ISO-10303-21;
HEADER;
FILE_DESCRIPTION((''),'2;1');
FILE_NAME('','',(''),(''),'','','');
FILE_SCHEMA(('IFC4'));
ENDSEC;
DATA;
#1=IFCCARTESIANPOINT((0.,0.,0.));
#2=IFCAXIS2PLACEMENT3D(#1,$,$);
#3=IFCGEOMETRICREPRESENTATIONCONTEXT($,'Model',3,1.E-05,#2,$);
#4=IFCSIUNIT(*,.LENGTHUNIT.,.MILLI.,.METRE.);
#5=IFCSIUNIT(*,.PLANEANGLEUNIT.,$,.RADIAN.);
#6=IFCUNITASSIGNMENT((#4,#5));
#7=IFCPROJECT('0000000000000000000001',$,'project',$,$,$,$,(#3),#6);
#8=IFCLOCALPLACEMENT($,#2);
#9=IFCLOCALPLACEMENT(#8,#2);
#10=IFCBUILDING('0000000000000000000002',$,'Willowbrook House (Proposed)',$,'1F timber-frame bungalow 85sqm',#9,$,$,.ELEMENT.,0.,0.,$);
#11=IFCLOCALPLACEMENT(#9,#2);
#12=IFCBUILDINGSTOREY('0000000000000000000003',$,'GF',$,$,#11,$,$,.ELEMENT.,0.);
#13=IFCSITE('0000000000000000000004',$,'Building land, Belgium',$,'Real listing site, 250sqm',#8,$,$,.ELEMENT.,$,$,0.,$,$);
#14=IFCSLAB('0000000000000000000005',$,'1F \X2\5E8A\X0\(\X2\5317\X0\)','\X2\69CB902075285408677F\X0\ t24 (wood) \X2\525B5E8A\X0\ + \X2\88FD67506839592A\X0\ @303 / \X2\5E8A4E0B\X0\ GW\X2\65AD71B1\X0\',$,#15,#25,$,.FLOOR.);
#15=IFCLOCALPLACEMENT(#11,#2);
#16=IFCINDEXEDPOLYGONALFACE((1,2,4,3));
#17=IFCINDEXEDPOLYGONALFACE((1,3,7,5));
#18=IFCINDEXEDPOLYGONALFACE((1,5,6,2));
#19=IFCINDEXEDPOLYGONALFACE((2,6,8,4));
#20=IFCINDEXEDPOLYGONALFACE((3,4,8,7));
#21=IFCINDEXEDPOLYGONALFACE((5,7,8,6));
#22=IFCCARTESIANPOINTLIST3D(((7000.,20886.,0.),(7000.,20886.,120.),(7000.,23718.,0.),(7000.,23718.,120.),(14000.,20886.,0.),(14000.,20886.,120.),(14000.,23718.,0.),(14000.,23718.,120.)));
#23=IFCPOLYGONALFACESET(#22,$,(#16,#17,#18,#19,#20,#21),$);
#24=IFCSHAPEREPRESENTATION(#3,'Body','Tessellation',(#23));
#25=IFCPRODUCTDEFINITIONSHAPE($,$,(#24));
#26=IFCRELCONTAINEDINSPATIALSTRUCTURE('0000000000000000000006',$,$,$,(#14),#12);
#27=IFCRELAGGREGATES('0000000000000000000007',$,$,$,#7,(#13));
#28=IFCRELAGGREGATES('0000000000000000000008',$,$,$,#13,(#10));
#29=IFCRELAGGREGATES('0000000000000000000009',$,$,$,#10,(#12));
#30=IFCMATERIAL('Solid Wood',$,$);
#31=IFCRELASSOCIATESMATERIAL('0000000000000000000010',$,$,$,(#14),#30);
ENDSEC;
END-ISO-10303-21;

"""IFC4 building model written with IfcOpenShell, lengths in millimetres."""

from ifc_helpers import new_model, si_unit, frame, frame_2d, origin, place, context, project, spatial, rectangle, extrude, material, element, save


model = new_model("IFC4")

# Units and contexts
model_context = context("Model", 3, precision=1e-05, world=origin())
ifc_project = project(units=[si_unit("LENGTHUNIT", "METRE", prefix="MILLI"), si_unit("PLANEANGLEUNIT", "RADIAN")], contexts=[model_context])

# Site, building, storey
site_placement = place(None, origin())
site = spatial("IfcSite", under=ifc_project, at=site_placement, Name="Building land, Belgium", ObjectType="Real listing site, 250sqm", CompositionType="ELEMENT", RefElevation=0.0)
building_placement = place(site_placement, origin())
building = spatial("IfcBuilding", under=site, at=building_placement, Name="Willowbrook House (Proposed)", ObjectType="1F timber-frame bungalow 85sqm", CompositionType="ELEMENT", ElevationOfRefHeight=0.0, ElevationOfTerrain=0.0)
storey_placement = place(building_placement, origin())
storey = spatial("IfcBuildingStorey", under=building, at=storey_placement, Name="GF", CompositionType="ELEMENT", Elevation=0.0)

# Slab
ifc_material_1 = material(Name="Solid Wood")
slab_1_placement = place(storey_placement, frame((3500.0, 10443.0, 0.0)))
element("IfcSlab", 1, at=slab_1_placement, inside=storey, material=ifc_material_1, Name="1F 床(北)", Description="構造用合板 t24 (wood) 剛床 + 製材根太 @303 / 床下 GW断熱", PredefinedType="FLOOR", context=model_context, shape_type="SweptSolid", body=[
    extrude(rectangle(XDim=7000.0, YDim=2832.0, at=frame_2d((3500.0, 1416.0))), frame((3500.0, 10443.0, 0.0)), (0.0, 0.0, 1.0), 120.0),
])

save(model, "model.ifc")
